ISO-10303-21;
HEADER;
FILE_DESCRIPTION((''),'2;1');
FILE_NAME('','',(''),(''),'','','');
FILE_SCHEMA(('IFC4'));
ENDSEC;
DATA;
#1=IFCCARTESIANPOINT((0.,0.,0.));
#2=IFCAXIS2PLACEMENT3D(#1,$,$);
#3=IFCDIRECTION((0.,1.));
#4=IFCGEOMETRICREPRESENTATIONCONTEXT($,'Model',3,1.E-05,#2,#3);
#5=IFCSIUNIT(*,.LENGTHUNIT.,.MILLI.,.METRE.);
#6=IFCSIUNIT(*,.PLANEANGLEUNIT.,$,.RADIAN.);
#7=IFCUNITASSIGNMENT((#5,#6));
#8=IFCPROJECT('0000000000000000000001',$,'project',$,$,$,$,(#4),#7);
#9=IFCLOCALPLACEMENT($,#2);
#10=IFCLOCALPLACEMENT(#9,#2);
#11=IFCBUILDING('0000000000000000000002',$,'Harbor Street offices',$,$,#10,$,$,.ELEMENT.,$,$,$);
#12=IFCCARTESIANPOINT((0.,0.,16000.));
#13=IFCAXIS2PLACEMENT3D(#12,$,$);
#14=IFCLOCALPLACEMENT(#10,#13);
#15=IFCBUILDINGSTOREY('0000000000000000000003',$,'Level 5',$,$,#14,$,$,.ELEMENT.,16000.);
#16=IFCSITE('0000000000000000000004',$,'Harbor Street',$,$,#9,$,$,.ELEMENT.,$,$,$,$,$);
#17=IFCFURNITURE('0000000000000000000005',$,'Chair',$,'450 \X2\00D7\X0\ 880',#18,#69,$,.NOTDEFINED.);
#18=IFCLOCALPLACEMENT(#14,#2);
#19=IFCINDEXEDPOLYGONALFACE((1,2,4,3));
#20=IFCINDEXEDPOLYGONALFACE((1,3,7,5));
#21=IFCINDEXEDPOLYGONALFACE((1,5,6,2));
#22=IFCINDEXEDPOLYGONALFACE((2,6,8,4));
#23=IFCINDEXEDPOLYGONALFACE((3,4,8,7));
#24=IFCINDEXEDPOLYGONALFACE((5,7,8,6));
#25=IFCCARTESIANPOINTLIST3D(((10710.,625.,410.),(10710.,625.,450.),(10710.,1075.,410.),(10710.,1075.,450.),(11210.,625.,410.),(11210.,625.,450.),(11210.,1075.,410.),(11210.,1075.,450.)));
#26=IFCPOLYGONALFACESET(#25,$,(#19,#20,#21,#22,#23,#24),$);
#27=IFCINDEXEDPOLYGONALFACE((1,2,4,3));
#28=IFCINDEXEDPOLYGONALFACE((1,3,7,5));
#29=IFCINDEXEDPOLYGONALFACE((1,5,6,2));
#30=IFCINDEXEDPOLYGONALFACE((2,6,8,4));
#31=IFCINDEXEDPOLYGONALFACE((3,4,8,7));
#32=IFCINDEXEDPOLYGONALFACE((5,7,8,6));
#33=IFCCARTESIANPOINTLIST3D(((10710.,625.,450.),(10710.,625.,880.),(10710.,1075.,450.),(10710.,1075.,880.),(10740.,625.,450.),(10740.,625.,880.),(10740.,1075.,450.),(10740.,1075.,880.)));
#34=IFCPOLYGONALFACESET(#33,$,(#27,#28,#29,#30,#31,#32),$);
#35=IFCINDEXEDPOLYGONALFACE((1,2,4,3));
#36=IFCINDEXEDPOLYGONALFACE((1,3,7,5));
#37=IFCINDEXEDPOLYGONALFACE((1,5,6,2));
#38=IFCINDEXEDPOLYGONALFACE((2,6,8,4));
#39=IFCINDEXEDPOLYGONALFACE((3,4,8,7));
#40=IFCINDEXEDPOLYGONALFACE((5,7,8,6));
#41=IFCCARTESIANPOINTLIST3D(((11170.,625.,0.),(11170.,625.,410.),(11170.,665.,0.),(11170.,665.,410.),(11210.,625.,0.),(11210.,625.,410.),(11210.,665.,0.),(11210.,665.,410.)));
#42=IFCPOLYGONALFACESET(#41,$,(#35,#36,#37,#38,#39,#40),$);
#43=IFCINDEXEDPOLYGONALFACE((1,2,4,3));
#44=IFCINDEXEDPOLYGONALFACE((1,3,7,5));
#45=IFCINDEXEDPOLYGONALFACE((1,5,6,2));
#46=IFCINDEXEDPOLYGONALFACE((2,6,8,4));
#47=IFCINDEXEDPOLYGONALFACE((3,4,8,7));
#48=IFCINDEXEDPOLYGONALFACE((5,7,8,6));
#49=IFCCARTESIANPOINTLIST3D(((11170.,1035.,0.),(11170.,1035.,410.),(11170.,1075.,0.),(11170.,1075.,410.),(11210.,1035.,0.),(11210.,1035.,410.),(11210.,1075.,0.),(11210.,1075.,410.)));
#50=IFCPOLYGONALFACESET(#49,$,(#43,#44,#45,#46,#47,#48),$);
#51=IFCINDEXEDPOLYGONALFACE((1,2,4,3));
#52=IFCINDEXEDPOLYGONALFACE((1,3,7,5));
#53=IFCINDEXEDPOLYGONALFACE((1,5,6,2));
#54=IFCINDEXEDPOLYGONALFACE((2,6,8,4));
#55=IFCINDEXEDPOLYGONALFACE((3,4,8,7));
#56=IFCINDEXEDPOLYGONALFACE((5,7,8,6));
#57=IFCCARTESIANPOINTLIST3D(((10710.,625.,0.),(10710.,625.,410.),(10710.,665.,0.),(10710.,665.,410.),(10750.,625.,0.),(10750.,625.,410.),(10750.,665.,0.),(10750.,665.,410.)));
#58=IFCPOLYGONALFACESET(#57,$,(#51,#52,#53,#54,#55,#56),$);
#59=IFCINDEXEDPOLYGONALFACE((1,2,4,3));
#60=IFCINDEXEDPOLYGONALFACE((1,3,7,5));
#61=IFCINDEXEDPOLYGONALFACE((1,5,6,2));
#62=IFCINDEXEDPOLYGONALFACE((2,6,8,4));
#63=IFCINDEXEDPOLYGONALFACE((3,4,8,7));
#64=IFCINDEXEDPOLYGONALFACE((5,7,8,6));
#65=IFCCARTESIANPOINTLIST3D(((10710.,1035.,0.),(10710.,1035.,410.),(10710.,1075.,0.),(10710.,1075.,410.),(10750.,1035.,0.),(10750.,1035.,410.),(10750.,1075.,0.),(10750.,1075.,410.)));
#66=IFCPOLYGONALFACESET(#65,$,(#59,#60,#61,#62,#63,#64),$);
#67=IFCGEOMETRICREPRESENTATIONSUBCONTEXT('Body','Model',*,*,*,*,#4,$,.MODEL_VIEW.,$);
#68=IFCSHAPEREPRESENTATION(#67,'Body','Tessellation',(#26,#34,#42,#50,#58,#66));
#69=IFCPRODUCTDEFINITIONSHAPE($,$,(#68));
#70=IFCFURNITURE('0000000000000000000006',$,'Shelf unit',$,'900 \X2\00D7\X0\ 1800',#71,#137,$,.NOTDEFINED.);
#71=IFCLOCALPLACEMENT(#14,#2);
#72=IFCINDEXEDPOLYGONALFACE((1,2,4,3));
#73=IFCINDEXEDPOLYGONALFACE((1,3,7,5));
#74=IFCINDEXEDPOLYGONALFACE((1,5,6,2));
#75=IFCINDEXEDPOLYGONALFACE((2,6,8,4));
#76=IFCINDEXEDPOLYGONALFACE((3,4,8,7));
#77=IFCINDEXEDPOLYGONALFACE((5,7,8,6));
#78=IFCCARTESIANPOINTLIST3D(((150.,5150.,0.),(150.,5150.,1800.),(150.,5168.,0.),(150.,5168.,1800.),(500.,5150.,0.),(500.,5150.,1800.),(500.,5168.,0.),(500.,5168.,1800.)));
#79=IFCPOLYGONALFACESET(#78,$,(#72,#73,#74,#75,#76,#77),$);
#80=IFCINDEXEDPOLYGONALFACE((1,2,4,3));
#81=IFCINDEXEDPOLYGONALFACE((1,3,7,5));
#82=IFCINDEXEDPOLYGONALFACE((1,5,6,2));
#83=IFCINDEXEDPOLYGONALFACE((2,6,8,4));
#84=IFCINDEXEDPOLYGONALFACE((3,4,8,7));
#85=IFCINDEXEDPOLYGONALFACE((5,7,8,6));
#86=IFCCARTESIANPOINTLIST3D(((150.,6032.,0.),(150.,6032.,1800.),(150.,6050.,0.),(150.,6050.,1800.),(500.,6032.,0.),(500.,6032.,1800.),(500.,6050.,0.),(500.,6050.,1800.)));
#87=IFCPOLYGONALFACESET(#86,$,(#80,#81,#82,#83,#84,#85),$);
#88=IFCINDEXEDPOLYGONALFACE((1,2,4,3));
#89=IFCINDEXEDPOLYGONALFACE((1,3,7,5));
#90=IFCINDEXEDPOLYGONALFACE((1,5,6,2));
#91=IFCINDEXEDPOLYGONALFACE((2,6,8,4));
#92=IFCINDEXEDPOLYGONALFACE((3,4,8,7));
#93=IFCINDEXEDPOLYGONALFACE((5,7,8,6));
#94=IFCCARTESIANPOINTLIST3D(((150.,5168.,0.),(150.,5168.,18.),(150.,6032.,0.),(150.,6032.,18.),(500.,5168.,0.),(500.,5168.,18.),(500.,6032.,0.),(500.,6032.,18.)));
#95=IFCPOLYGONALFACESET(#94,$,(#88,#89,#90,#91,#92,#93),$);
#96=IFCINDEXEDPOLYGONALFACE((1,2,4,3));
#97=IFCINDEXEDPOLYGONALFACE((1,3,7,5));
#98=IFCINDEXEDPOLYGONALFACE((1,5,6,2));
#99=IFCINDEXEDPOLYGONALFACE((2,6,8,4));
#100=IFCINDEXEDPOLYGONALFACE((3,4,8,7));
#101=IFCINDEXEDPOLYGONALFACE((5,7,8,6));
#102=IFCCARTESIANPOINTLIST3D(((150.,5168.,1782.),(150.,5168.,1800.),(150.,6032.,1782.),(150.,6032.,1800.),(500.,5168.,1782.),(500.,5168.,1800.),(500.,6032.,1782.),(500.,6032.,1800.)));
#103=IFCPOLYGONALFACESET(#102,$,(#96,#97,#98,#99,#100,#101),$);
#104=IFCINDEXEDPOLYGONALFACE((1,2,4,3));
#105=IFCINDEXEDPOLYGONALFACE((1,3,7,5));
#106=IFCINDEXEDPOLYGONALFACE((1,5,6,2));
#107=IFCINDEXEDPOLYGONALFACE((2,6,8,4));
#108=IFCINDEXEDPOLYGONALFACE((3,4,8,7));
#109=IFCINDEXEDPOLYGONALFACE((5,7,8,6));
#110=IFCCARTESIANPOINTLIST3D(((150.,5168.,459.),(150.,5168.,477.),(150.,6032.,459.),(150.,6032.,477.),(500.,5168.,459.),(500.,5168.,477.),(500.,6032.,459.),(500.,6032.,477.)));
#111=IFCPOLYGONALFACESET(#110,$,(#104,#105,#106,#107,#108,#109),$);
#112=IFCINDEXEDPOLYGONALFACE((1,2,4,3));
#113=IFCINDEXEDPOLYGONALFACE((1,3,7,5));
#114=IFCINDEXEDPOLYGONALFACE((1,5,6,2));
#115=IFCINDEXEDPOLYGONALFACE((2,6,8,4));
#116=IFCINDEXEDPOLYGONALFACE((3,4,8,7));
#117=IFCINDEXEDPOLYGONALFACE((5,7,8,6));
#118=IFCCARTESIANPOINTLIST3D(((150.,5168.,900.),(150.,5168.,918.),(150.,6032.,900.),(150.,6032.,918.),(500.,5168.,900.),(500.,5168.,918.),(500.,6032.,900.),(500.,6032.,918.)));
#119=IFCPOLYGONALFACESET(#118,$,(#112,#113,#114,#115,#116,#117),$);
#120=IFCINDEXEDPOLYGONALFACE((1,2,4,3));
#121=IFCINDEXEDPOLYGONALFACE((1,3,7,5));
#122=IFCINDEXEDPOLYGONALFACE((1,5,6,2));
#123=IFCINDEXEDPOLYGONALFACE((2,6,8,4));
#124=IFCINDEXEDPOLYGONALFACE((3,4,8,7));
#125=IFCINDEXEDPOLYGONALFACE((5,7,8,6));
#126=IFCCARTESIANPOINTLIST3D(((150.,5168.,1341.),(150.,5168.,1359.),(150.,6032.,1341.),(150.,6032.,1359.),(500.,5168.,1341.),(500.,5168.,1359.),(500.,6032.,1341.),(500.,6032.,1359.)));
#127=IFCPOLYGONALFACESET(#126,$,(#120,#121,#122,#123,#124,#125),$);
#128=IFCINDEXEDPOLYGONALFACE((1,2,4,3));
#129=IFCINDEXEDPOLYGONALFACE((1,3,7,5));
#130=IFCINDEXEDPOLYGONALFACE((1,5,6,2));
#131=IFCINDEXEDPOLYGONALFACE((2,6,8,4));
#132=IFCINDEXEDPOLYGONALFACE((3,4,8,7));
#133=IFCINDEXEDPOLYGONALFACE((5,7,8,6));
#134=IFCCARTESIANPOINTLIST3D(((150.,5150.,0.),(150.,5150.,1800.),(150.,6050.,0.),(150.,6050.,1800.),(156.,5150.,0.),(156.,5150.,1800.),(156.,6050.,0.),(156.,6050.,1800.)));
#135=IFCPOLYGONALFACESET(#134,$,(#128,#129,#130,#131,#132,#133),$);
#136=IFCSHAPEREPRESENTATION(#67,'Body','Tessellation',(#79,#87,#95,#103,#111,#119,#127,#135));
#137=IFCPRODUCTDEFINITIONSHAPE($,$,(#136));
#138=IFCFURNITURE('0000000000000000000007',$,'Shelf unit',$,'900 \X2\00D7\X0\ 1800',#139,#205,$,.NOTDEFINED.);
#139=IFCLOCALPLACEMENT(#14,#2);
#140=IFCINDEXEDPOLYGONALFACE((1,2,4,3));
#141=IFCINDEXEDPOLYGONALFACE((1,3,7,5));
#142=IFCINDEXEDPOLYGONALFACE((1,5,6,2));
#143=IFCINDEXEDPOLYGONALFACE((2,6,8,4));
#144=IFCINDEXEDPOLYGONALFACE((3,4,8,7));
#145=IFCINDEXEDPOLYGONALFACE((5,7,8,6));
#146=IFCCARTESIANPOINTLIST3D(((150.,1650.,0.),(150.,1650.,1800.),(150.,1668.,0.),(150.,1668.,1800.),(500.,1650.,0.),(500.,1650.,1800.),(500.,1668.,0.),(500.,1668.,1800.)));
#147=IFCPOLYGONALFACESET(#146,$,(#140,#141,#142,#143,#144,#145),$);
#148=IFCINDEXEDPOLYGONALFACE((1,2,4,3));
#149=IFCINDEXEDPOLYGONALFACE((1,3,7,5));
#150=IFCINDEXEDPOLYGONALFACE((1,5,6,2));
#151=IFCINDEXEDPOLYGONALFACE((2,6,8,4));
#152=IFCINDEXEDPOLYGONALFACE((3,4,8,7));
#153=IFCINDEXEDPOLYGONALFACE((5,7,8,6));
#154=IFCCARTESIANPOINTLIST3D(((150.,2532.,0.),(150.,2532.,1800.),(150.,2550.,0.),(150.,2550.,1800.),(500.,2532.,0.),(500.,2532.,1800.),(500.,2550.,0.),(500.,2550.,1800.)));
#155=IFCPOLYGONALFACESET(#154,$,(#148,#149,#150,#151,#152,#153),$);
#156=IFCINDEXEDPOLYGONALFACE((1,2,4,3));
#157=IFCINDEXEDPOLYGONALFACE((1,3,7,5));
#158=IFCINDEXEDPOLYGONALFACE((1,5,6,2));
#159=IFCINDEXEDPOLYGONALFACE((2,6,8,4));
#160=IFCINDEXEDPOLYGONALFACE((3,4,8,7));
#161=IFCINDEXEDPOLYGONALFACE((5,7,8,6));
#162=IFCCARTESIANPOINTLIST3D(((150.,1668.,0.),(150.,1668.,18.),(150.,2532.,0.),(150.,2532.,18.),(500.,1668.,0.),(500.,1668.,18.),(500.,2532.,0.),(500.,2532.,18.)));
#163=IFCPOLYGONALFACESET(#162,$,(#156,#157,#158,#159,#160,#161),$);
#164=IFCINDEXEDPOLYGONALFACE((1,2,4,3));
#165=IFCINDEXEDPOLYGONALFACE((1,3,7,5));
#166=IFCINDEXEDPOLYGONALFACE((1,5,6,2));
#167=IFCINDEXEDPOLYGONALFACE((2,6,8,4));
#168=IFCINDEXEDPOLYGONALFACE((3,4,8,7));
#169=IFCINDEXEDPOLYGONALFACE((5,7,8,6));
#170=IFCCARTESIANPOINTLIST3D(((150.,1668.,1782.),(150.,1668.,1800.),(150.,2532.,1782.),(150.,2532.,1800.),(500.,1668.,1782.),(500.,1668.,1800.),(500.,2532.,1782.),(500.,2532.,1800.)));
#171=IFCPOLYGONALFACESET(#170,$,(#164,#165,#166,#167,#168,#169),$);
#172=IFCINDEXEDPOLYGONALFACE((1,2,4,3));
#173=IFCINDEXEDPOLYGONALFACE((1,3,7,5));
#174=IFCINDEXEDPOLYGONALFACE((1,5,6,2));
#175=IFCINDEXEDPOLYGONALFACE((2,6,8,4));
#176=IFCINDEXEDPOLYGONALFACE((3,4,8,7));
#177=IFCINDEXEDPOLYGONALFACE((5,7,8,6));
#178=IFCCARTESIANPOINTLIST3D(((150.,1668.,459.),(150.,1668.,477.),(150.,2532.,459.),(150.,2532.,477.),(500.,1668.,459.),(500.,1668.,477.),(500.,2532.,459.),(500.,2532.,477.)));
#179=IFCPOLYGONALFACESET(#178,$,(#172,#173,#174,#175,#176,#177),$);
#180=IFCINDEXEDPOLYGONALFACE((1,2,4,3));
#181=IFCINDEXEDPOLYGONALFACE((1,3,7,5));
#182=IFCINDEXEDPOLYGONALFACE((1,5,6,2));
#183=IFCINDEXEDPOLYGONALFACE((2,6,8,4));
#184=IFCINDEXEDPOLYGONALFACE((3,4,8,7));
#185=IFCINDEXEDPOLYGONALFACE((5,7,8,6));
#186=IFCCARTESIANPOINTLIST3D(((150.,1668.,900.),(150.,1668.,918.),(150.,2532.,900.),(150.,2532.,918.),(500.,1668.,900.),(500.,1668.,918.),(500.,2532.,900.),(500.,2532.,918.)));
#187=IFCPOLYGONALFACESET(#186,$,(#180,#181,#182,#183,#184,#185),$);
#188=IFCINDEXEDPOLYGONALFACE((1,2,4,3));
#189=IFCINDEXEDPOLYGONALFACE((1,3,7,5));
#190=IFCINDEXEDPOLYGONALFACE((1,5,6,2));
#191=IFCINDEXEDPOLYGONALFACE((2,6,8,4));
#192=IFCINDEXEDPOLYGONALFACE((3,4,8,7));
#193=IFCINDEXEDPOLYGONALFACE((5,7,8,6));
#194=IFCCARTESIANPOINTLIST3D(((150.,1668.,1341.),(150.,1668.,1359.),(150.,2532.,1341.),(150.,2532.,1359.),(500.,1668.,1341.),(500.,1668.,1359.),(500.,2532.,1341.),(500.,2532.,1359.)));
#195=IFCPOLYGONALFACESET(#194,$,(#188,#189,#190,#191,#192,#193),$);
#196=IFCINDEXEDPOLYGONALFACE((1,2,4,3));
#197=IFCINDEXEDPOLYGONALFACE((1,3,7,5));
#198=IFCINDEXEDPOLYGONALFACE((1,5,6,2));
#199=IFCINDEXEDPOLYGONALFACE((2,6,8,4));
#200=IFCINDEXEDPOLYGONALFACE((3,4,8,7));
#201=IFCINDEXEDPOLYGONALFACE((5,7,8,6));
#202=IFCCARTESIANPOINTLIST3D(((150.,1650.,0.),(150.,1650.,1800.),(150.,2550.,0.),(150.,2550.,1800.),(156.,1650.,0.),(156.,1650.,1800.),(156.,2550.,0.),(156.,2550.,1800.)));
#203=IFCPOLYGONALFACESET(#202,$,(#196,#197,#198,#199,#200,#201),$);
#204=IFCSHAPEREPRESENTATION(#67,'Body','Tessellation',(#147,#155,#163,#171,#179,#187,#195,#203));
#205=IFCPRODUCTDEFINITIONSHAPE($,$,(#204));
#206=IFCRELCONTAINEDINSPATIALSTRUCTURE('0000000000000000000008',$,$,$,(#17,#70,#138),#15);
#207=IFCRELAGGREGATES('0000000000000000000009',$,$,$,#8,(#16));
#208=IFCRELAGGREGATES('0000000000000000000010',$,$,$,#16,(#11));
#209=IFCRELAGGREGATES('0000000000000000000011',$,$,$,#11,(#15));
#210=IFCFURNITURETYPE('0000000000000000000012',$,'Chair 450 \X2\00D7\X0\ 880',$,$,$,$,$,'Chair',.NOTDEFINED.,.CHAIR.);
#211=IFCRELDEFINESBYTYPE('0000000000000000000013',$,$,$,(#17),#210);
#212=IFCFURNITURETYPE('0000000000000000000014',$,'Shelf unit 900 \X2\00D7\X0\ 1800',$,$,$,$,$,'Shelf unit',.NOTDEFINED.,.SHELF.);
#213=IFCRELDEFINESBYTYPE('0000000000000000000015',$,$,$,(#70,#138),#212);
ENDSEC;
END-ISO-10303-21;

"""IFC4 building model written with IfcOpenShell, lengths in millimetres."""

from ifc_helpers import new_model, si_unit, direction, frame, origin, place, context, subcontext, project, spatial, polyline, outline, extrude, source, transform, mapped, type_object, type_shapes, element, save


model = new_model("IFC4")

# Units and contexts
model_context = context("Model", 3, precision=1e-05, world=origin(), true_north=direction((0.0, 1.0)))
body_context = subcontext(model_context, "Body", "Model", "MODEL_VIEW")
ifc_project = project(units=[si_unit("LENGTHUNIT", "METRE", prefix="MILLI"), si_unit("PLANEANGLEUNIT", "RADIAN")], contexts=[model_context])

# Site, building, storey
site_placement = place(None, origin())
site = spatial("IfcSite", under=ifc_project, at=site_placement, Name="Harbor Street", CompositionType="ELEMENT")
building_placement = place(site_placement, origin())
building = spatial("IfcBuilding", under=site, at=building_placement, Name="Harbor Street offices", CompositionType="ELEMENT")
storey_placement = place(building_placement, frame((0.0, 0.0, 16000.0)))
storey = spatial("IfcBuildingStorey", under=building, at=storey_placement, Name="Level 5", CompositionType="ELEMENT", Elevation=16000.0)

# Furniture
furniture_type_1 = type_object("IfcFurnitureType", Name="Chair 450 × 880", ElementType="Chair", AssemblyPlace="NOTDEFINED", PredefinedType="CHAIR")
shared_shape_1 = source(origin(), body_context, "Body", "SweptSolid", [
    extrude(outline(polyline([(-225.0, 0.0), (225.0, 0.0), (225.0, 500.0), (-225.0, 500.0), (-225.0, 0.0)])), frame((0.0, 0.0, 410.0)), (0.0, 0.0, 1.0), 40.0),
    extrude(outline(polyline([(-225.0, 470.0), (225.0, 470.0), (225.0, 500.0), (-225.0, 500.0), (-225.0, 470.0)])), frame((0.0, 0.0, 450.0)), (0.0, 0.0, 1.0), 430.0),
    extrude(outline(polyline([(-225.0, 0.0), (-185.0, 0.0), (-185.0, 40.0), (-225.0, 40.0), (-225.0, 0.0)])), origin(), (0.0, 0.0, 1.0), 410.0),
    extrude(outline(polyline([(185.0, 0.0), (225.0, 0.0), (225.0, 40.0), (185.0, 40.0), (185.0, 0.0)])), origin(), (0.0, 0.0, 1.0), 410.0),
    extrude(outline(polyline([(-225.0, 460.0), (-185.0, 460.0), (-185.0, 500.0), (-225.0, 500.0), (-225.0, 460.0)])), origin(), (0.0, 0.0, 1.0), 410.0),
    extrude(outline(polyline([(185.0, 460.0), (225.0, 460.0), (225.0, 500.0), (185.0, 500.0), (185.0, 460.0)])), origin(), (0.0, 0.0, 1.0), 410.0),
])
type_shapes(furniture_type_1, [shared_shape_1])
for number, where, z_axis, x_axis, name in (
    (1, (11210.0, 850.0, 0.0), (0.0, 0.0, 1.0), (0.0, 1.0, 0.0), "Chair"),
):
    element("IfcFurniture", number, at=place(storey_placement, frame(where, z_axis=z_axis, x_axis=x_axis)), inside=storey, type_object=furniture_type_1, Name=name, ObjectType="450 × 880", PredefinedType="NOTDEFINED", context=body_context, shape_type="MappedRepresentation", body=[
        mapped(shared_shape_1, transform((0.0, 0.0, 0.0))),
    ])
furniture_type_2 = type_object("IfcFurnitureType", Name="Shelf unit 900 × 1800", ElementType="Shelf unit", AssemblyPlace="NOTDEFINED", PredefinedType="SHELF")
shared_shape_2 = source(origin(), body_context, "Body", "SweptSolid", [
    extrude(outline(polyline([(-450.0, 0.0), (-432.0, 0.0), (-432.0, 350.0), (-450.0, 350.0), (-450.0, 0.0)])), origin(), (0.0, 0.0, 1.0), 1800.0),
    extrude(outline(polyline([(432.0, 0.0), (450.0, 0.0), (450.0, 350.0), (432.0, 350.0), (432.0, 0.0)])), origin(), (0.0, 0.0, 1.0), 1800.0),
    extrude(outline(polyline([(-432.0, 0.0), (432.0, 0.0), (432.0, 350.0), (-432.0, 350.0), (-432.0, 0.0)])), origin(), (0.0, 0.0, 1.0), 18.0),
    extrude(outline(polyline([(-432.0, 0.0), (432.0, 0.0), (432.0, 350.0), (-432.0, 350.0), (-432.0, 0.0)])), frame((0.0, 0.0, 1782.0)), (0.0, 0.0, 1.0), 18.0),
    extrude(outline(polyline([(-432.0, 0.0), (432.0, 0.0), (432.0, 350.0), (-432.0, 350.0), (-432.0, 0.0)])), frame((0.0, 0.0, 459.0)), (0.0, 0.0, 1.0), 18.0),
    extrude(outline(polyline([(-432.0, 0.0), (432.0, 0.0), (432.0, 350.0), (-432.0, 350.0), (-432.0, 0.0)])), frame((0.0, 0.0, 900.0)), (0.0, 0.0, 1.0), 18.0),
    extrude(outline(polyline([(-432.0, 0.0), (432.0, 0.0), (432.0, 350.0), (-432.0, 350.0), (-432.0, 0.0)])), frame((0.0, 0.0, 1341.0)), (0.0, 0.0, 1.0), 18.0),
    extrude(outline(polyline([(-450.0, 344.0), (450.0, 344.0), (450.0, 350.0), (-450.0, 350.0), (-450.0, 344.0)])), origin(), (0.0, 0.0, 1.0), 1800.0),
])
type_shapes(furniture_type_2, [shared_shape_2])
for number, where, z_axis, x_axis, name in (
    (2, (500.0, 5600.0, 0.0), (0.0, 0.0, 1.0), (0.0, 1.0, 0.0), "Shelf unit"),
    (3, (500.0, 2100.0, 0.0), (0.0, 0.0, 1.0), (0.0, 1.0, 0.0), "Shelf unit"),
):
    element("IfcFurniture", number, at=place(storey_placement, frame(where, z_axis=z_axis, x_axis=x_axis)), inside=storey, type_object=furniture_type_2, Name=name, ObjectType="900 × 1800", PredefinedType="NOTDEFINED", context=body_context, shape_type="MappedRepresentation", body=[
        mapped(shared_shape_2, transform((0.0, 0.0, 0.0))),
    ])

save(model, "model.ifc")
